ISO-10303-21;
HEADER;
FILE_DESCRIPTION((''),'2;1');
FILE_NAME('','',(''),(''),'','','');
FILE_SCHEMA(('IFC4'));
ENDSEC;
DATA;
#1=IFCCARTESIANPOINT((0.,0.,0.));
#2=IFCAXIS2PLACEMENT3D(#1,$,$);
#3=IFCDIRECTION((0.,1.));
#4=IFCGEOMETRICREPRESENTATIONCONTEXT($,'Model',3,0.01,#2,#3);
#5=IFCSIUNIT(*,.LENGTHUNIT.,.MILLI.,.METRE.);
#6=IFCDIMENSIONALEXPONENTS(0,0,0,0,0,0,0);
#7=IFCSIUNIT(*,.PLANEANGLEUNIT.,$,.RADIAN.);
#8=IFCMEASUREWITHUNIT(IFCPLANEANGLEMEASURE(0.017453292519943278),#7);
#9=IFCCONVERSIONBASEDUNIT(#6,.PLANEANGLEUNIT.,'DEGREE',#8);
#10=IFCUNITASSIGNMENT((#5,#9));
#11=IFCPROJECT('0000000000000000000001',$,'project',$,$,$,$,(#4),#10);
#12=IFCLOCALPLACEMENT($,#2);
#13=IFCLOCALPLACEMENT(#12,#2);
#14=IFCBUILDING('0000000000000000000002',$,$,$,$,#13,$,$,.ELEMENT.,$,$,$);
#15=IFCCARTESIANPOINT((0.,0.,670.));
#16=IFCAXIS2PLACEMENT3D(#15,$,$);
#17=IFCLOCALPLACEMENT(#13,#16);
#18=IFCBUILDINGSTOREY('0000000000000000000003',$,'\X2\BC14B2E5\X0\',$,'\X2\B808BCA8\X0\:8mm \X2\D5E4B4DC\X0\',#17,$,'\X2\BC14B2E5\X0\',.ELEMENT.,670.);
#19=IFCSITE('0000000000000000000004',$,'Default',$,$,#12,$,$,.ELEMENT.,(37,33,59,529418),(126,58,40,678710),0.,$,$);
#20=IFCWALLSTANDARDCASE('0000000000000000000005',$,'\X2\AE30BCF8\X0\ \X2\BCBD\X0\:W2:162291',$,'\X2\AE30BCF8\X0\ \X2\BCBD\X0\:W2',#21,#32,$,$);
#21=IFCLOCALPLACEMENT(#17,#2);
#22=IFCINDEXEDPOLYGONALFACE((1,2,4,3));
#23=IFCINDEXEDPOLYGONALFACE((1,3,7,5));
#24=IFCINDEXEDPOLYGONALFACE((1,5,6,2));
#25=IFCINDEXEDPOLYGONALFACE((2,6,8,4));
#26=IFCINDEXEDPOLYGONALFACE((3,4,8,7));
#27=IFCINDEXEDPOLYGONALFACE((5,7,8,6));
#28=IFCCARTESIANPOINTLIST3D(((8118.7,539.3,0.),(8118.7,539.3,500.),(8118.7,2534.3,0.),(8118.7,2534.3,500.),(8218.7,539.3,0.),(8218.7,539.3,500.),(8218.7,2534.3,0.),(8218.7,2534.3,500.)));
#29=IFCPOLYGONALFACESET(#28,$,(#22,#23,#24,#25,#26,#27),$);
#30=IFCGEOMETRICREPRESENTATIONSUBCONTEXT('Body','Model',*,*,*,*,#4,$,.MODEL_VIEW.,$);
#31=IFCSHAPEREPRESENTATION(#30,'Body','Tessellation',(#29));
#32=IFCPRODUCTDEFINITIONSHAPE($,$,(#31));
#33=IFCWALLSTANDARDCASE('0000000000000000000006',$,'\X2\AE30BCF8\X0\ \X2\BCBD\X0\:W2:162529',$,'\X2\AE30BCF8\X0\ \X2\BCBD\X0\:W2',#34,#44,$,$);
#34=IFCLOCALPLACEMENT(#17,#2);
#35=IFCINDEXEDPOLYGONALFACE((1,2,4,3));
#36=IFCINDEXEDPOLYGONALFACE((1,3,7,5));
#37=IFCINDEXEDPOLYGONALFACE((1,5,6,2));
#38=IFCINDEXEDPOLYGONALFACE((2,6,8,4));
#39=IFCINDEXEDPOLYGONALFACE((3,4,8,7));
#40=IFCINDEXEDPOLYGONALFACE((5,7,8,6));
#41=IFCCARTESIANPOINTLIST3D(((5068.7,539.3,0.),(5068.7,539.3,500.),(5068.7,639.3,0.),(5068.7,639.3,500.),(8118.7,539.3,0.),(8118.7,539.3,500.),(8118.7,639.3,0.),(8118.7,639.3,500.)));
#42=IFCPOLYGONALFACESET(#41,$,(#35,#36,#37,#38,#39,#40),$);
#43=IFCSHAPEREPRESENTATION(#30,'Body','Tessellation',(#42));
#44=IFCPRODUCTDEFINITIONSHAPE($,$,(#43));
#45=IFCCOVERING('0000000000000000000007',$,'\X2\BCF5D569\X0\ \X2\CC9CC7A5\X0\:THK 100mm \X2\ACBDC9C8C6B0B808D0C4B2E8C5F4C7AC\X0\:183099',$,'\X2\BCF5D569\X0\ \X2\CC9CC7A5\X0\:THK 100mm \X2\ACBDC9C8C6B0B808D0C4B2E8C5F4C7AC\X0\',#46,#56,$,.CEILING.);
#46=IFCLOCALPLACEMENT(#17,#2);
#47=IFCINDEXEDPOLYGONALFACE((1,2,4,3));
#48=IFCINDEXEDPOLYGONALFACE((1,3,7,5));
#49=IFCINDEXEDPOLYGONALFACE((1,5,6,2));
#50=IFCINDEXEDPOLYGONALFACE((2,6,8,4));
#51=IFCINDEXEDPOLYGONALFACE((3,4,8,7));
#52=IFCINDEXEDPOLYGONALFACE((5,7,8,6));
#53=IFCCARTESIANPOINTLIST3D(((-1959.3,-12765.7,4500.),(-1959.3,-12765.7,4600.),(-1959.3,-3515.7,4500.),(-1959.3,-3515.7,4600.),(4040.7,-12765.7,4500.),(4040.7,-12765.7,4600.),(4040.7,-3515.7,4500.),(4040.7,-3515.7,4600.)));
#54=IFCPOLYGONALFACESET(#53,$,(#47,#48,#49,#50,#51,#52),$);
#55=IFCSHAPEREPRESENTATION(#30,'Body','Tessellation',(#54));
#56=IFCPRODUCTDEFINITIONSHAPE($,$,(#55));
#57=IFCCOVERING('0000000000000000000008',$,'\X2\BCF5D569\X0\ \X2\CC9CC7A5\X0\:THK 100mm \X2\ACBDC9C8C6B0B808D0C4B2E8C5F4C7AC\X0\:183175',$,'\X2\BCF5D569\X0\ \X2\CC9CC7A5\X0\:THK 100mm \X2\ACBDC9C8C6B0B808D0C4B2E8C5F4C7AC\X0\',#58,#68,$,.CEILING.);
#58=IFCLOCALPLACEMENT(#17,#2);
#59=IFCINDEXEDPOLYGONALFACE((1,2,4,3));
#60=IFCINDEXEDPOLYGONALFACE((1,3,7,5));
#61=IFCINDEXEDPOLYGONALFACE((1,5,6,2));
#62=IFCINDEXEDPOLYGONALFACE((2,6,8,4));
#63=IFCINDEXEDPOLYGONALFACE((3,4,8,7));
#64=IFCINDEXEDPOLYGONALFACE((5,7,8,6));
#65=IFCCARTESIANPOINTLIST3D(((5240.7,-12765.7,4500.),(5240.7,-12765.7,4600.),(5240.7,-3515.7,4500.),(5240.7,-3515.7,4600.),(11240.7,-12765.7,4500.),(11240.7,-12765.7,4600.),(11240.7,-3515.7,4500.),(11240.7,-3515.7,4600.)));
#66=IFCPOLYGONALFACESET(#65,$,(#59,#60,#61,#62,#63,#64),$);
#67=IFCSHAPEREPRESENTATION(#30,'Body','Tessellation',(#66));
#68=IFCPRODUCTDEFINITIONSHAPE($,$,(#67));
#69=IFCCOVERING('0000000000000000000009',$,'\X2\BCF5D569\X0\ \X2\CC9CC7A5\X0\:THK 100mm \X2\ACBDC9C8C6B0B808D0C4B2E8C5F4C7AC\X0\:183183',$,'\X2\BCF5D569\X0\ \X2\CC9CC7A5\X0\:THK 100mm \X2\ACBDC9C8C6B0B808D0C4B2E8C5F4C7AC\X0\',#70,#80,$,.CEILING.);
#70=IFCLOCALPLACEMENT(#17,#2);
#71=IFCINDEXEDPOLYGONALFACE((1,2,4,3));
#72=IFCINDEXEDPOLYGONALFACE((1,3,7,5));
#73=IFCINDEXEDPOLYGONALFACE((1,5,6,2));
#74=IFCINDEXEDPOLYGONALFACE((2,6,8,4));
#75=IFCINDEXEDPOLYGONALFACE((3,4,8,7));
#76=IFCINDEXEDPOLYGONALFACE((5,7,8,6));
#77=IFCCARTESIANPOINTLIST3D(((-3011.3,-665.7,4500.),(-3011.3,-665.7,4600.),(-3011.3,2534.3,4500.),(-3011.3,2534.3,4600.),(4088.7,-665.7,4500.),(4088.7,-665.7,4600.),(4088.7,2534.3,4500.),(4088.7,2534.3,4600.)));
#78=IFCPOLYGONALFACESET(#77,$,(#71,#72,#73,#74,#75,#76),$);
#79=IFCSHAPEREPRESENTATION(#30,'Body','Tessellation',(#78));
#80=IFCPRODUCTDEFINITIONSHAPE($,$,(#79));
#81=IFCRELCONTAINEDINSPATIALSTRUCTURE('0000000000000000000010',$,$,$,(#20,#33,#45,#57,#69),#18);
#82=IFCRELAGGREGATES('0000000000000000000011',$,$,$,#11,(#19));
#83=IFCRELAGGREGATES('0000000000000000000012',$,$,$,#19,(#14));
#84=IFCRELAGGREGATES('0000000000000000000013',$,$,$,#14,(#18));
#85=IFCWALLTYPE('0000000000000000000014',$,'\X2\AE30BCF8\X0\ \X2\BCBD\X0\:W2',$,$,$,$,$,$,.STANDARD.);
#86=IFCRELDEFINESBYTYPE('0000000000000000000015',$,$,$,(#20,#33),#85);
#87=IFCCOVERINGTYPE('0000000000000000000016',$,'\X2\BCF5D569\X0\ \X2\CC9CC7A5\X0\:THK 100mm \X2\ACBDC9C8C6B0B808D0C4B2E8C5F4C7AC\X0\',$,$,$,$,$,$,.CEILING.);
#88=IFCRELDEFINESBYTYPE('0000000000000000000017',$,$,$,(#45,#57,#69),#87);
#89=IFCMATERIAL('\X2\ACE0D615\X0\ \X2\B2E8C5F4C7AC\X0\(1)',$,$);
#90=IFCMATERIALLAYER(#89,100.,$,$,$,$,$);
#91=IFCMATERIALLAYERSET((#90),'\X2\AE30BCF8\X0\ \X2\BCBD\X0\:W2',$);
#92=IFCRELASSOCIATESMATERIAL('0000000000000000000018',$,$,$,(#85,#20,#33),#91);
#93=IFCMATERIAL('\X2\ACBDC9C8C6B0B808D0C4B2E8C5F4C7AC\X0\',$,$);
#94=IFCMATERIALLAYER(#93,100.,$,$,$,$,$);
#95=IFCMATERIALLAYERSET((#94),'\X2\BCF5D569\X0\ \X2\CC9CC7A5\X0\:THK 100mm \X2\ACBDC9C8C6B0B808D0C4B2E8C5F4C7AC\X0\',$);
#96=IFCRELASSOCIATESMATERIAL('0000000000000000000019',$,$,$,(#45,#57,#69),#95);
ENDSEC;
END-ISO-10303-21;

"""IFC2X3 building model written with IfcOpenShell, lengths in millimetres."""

from ifc_helpers import new_model, entity, si_unit, converted_unit, direction, frame, frame_2d, origin, place, context, subcontext, project, spatial, rectangle, extrude, material, layer, layer_set, layer_usage, type_object, element, save


model = new_model("IFC2X3")

# Units and contexts
model_context = context("Model", 3, precision=0.01, world=origin(), true_north=direction((0.0, 1.0)))
body_context = subcontext(model_context, "Body", "Model", "MODEL_VIEW")
ifc_project = project(units=[si_unit("LENGTHUNIT", "METRE", prefix="MILLI"), converted_unit("PLANEANGLEUNIT", "DEGREE", entity("IfcPlaneAngleMeasure", 0.017453292519943278), si_unit("PLANEANGLEUNIT", "RADIAN"), dimensions=[0, 0, 0, 0, 0, 0, 0])], contexts=[model_context])

# Site, building, storey
site_placement = place(None, origin())
site = spatial("IfcSite", under=ifc_project, at=site_placement, Name="Default", CompositionType="ELEMENT", RefLatitude=(37, 33, 59, 529418), RefLongitude=(126, 58, 40, 678710), RefElevation=0.0)
building_placement = place(site_placement, origin())
building = spatial("IfcBuilding", under=site, at=building_placement, CompositionType="ELEMENT")
storey_placement = place(building_placement, frame((0.0, 0.0, 670.0)))
storey = spatial("IfcBuildingStorey", under=building, at=storey_placement, Name="바닥", ObjectType="레벨:8mm 헤드", LongName="바닥", CompositionType="ELEMENT", Elevation=670.0)

# Shared definitions
ifc_material_1 = material(Name="고형 단열재(1)")
ifc_layer_1 = layer(ifc_material_1, 100.0)
ifc_layer_set_1 = layer_set([ifc_layer_1], Name="기본 벽:W2")
wall_type_1 = type_object("IfcWallType", Name="기본 벽:W2", PredefinedType="STANDARD", material=ifc_layer_set_1)

# Walls
ifc_layer_usage_1 = layer_usage(ifc_layer_set_1, "AXIS2", "NEGATIVE", 50.0)
wall_1_placement = place(storey_placement, frame((8168.7, 539.3, 0.0), z_axis=(0.0, 0.0, 1.0), x_axis=(0.0, 1.0, 0.0)))
element("IfcWallStandardCase", 1, at=wall_1_placement, inside=storey, type_object=wall_type_1, material=ifc_layer_usage_1, Name="기본 벽:W2:162291", ObjectType="기본 벽:W2", context=body_context, shape_type="SweptSolid", body=[
    extrude(rectangle(XDim=1995.0, YDim=100.0, at=frame_2d((997.5, 0.0), x_axis=(-1.0, 0.0))), origin(), (0.0, 0.0, 1.0), 500.0),
])
ifc_layer_usage_2 = layer_usage(ifc_layer_set_1, "AXIS2", "NEGATIVE", 50.0)
wall_2_placement = place(storey_placement, frame((5068.7, 589.3, 0.0)))
element("IfcWallStandardCase", 2, at=wall_2_placement, inside=storey, type_object=wall_type_1, material=ifc_layer_usage_2, Name="기본 벽:W2:162529", ObjectType="기본 벽:W2", context=body_context, shape_type="SweptSolid", body=[
    extrude(rectangle(XDim=3050.0, YDim=100.0, at=frame_2d((1525.0, 0.0), x_axis=(-1.0, 0.0))), origin(), (0.0, 0.0, 1.0), 500.0),
])

# Coverings
ifc_material_2 = material(Name="경질우레탄단열재")
ifc_layer_2 = layer(ifc_material_2, 100.0)
ifc_layer_set_2 = layer_set([ifc_layer_2], Name="복합 천장:THK 100mm 경질우레탄단열재")
ifc_layer_usage_3 = layer_usage(ifc_layer_set_2, "AXIS3", "NEGATIVE", 100.0)
covering_type = type_object("IfcCoveringType", Name="복합 천장:THK 100mm 경질우레탄단열재", PredefinedType="CEILING")
covering_1_placement = place(storey_placement, origin())
element("IfcCovering", 3, at=covering_1_placement, inside=storey, type_object=covering_type, material=ifc_layer_usage_3, Name="복합 천장:THK 100mm 경질우레탄단열재:183099", ObjectType="복합 천장:THK 100mm 경질우레탄단열재", PredefinedType="CEILING", context=body_context, shape_type="SweptSolid", body=[
    extrude(rectangle(XDim=9250.0, YDim=6000.0, at=frame_2d((0.0, 0.0), x_axis=(1.0, 0.0))), frame((1040.7, -8140.7, 4500.0), z_axis=(0.0, 0.0, 1.0), x_axis=(0.0, 1.0, 0.0)), (0.0, 0.0, 1.0), 100.0),
])
ifc_layer_usage_4 = layer_usage(ifc_layer_set_2, "AXIS3", "NEGATIVE", 100.0)
covering_2_placement = place(storey_placement, origin())
element("IfcCovering", 4, at=covering_2_placement, inside=storey, type_object=covering_type, material=ifc_layer_usage_4, Name="복합 천장:THK 100mm 경질우레탄단열재:183175", ObjectType="복합 천장:THK 100mm 경질우레탄단열재", PredefinedType="CEILING", context=body_context, shape_type="SweptSolid", body=[
    extrude(rectangle(XDim=9250.0, YDim=6000.0, at=frame_2d((0.0, 0.0), x_axis=(1.0, 0.0))), frame((8240.7, -8140.7, 4500.0), z_axis=(0.0, 0.0, 1.0), x_axis=(0.0, 1.0, 0.0)), (0.0, 0.0, 1.0), 100.0),
])
ifc_layer_usage_5 = layer_usage(ifc_layer_set_2, "AXIS3", "NEGATIVE", 100.0)
covering_3_placement = place(storey_placement, origin())
element("IfcCovering", 5, at=covering_3_placement, inside=storey, type_object=covering_type, material=ifc_layer_usage_5, Name="복합 천장:THK 100mm 경질우레탄단열재:183183", ObjectType="복합 천장:THK 100mm 경질우레탄단열재", PredefinedType="CEILING", context=body_context, shape_type="SweptSolid", body=[
    extrude(rectangle(XDim=7100.0, YDim=3200.0, at=frame_2d((0.0, 0.0), x_axis=(1.0, 0.0))), frame((538.7, 934.3, 4500.0)), (0.0, 0.0, 1.0), 100.0),
])

save(model, "model.ifc")
